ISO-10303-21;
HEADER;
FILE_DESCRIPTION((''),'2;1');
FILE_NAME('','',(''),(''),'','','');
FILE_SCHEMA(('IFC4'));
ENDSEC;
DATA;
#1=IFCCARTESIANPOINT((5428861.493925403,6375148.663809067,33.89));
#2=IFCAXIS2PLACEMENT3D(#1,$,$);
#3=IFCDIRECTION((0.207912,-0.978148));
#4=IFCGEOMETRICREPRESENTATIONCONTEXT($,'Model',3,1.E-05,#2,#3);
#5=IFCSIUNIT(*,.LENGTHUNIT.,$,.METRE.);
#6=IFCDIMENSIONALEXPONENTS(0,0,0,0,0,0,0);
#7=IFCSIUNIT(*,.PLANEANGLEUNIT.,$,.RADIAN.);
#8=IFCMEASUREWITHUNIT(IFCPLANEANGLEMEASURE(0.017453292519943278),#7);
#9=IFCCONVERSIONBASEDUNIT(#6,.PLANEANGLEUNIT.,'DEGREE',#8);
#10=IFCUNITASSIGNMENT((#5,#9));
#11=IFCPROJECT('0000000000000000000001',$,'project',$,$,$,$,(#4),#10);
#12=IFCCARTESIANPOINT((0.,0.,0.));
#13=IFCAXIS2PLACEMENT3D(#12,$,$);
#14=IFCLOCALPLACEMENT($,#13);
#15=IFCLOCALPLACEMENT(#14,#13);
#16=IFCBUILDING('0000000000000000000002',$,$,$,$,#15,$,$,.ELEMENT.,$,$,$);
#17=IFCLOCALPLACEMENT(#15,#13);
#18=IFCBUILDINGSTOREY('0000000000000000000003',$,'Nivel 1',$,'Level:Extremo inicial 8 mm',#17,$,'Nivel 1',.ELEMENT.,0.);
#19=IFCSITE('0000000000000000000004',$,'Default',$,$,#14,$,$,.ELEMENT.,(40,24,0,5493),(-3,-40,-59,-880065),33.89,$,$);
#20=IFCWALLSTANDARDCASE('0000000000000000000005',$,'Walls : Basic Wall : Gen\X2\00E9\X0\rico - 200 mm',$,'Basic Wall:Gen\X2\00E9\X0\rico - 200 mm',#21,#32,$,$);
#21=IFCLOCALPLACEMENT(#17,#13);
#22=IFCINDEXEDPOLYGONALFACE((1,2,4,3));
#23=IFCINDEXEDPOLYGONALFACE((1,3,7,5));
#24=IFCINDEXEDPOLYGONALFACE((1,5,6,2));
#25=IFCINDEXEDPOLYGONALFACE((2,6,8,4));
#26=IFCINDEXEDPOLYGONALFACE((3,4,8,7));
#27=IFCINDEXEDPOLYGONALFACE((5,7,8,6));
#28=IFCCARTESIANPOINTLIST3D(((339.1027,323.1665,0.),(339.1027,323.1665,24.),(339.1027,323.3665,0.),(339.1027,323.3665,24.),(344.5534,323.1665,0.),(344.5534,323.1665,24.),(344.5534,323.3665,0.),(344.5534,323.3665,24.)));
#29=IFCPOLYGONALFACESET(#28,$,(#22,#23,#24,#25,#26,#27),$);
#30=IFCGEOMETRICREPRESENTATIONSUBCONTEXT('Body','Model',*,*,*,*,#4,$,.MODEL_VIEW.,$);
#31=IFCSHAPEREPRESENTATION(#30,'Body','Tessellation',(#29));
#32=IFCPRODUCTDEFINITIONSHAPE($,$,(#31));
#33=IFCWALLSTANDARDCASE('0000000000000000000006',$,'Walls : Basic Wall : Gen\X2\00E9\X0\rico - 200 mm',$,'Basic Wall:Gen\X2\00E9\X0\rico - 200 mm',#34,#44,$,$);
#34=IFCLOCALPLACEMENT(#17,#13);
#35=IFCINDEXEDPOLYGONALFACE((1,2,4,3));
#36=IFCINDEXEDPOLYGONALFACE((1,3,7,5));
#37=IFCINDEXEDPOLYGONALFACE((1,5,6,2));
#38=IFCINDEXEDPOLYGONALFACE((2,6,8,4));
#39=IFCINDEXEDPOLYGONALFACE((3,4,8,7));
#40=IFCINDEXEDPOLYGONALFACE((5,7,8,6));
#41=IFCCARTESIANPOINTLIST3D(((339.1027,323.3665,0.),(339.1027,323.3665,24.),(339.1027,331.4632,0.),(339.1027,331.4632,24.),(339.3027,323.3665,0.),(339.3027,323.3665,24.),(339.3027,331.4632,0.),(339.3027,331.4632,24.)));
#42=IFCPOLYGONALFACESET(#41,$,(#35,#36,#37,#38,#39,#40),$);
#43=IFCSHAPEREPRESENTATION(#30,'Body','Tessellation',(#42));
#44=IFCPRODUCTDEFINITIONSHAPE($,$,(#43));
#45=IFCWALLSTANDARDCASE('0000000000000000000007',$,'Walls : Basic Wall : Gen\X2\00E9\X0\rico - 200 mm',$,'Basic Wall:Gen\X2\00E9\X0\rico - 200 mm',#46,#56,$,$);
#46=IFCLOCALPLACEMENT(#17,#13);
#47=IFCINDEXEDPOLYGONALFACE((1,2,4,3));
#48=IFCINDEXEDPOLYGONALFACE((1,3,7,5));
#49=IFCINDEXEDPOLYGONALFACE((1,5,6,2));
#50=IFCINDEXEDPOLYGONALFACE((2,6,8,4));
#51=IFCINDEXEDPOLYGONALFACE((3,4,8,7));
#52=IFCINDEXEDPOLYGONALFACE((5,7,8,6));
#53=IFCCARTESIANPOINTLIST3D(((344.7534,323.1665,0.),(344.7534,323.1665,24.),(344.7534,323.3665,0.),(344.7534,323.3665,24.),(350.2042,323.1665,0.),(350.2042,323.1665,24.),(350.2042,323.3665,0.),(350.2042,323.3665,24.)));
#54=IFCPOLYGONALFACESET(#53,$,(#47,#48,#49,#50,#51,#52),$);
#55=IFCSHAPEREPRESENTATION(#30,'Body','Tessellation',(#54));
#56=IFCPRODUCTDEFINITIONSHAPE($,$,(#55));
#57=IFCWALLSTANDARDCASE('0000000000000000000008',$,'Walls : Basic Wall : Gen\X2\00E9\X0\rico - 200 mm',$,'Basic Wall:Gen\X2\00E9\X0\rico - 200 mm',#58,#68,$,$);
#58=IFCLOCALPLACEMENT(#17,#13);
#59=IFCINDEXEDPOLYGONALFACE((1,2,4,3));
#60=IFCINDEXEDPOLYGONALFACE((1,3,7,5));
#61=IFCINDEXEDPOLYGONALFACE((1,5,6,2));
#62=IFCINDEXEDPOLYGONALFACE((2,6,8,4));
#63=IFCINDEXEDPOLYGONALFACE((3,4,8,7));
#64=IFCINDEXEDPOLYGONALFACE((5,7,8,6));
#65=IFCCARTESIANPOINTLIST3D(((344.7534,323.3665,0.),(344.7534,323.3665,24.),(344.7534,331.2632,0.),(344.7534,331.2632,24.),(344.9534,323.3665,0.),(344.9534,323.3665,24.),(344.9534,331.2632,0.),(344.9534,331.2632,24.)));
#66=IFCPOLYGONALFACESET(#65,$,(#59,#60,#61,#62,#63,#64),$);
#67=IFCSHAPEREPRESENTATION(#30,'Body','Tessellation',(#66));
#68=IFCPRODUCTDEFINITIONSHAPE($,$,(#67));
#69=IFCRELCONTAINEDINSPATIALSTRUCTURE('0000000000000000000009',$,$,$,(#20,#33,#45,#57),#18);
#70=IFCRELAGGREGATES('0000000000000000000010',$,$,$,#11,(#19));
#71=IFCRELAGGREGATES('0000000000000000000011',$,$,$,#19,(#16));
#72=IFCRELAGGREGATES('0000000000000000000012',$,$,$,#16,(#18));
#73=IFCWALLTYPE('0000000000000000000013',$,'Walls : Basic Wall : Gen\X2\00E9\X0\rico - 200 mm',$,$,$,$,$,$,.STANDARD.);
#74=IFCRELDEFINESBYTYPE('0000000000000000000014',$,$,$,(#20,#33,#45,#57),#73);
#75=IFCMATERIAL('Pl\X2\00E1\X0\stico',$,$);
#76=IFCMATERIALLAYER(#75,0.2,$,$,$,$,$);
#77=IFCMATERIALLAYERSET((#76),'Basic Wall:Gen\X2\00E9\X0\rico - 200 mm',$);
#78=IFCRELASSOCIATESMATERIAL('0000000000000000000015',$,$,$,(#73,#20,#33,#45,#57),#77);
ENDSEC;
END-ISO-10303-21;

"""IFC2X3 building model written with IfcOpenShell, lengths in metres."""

from ifc_helpers import new_model, entity, si_unit, converted_unit, direction, frame, frame_2d, origin, place, context, subcontext, project, spatial, rectangle, extrude, material, layer, layer_set, layer_usage, type_object, element, save


model = new_model("IFC2X3")

# Units and contexts
model_context = context("Model", 3, precision=1e-05, world=frame((5428861.493925403, 6375148.663809067, 33.89)), true_north=direction((0.207912, -0.978148)))
body_context = subcontext(model_context, "Body", "Model", "MODEL_VIEW")
ifc_project = project(units=[si_unit("LENGTHUNIT", "METRE"), converted_unit("PLANEANGLEUNIT", "DEGREE", entity("IfcPlaneAngleMeasure", 0.017453292519943278), si_unit("PLANEANGLEUNIT", "RADIAN"), dimensions=[0, 0, 0, 0, 0, 0, 0])], contexts=[model_context])

# Site, building, storey
site_placement = place(None, origin())
site = spatial("IfcSite", under=ifc_project, at=site_placement, Name="Default", CompositionType="ELEMENT", RefLatitude=(40, 24, 0, 5493), RefLongitude=(-3, -40, -59, -880065), RefElevation=33.89)
building_placement = place(site_placement, origin())
building = spatial("IfcBuilding", under=site, at=building_placement, CompositionType="ELEMENT")
storey_placement = place(building_placement, origin())
storey = spatial("IfcBuildingStorey", under=building, at=storey_placement, Name="Nivel 1", ObjectType="Level:Extremo inicial 8 mm", LongName="Nivel 1", CompositionType="ELEMENT", Elevation=0.0)

# Walls
ifc_material = material(Name="Plástico")
ifc_layer = layer(ifc_material, 0.2)
ifc_layer_set = layer_set([ifc_layer], Name="Basic Wall:Genérico - 200 mm")
wall_type = type_object("IfcWallType", Name="Walls : Basic Wall : Genérico - 200 mm", PredefinedType="STANDARD", material=ifc_layer_set)
ifc_layer_usage_1 = layer_usage(ifc_layer_set, "AXIS2", "NEGATIVE", 0.1)
wall_1_placement = place(storey_placement, frame((344.5534, 323.2665, 0.0), z_axis=(0.0, 0.0, 1.0), x_axis=(-1.0, 0.0, 0.0)))
element("IfcWallStandardCase", 1, at=wall_1_placement, inside=storey, type_object=wall_type, material=ifc_layer_usage_1, Name="Walls : Basic Wall : Genérico - 200 mm", ObjectType="Basic Wall:Genérico - 200 mm", context=body_context, shape_type="SweptSolid", body=[
    extrude(rectangle(XDim=5.4508, YDim=0.2, at=frame_2d((2.7254, 0.0), x_axis=(-1.0, 0.0))), origin(), (0.0, 0.0, 1.0), 24.0),
])
ifc_layer_usage_2 = layer_usage(ifc_layer_set, "AXIS2", "NEGATIVE", 0.1)
wall_2_placement = place(storey_placement, frame((339.2027, 323.3665, 0.0), z_axis=(0.0, 0.0, 1.0), x_axis=(0.0, 1.0, 0.0)))
element("IfcWallStandardCase", 2, at=wall_2_placement, inside=storey, type_object=wall_type, material=ifc_layer_usage_2, Name="Walls : Basic Wall : Genérico - 200 mm", ObjectType="Basic Wall:Genérico - 200 mm", context=body_context, shape_type="SweptSolid", body=[
    extrude(rectangle(XDim=8.0967, YDim=0.2, at=frame_2d((4.0484, 0.0), x_axis=(-1.0, 0.0))), origin(), (0.0, 0.0, 1.0), 24.0),
])
ifc_layer_usage_3 = layer_usage(ifc_layer_set, "AXIS2", "NEGATIVE", 0.1)
wall_3_placement = place(storey_placement, frame((350.2042, 323.2665, 0.0), z_axis=(0.0, 0.0, 1.0), x_axis=(-1.0, 0.0, 0.0)))
element("IfcWallStandardCase", 3, at=wall_3_placement, inside=storey, type_object=wall_type, material=ifc_layer_usage_3, Name="Walls : Basic Wall : Genérico - 200 mm", ObjectType="Basic Wall:Genérico - 200 mm", context=body_context, shape_type="SweptSolid", body=[
    extrude(rectangle(XDim=5.4508, YDim=0.2, at=frame_2d((2.7254, 0.0), x_axis=(-1.0, 0.0))), origin(), (0.0, 0.0, 1.0), 24.0),
])
ifc_layer_usage_4 = layer_usage(ifc_layer_set, "AXIS2", "NEGATIVE", 0.1)
wall_4_placement = place(storey_placement, frame((344.8534, 323.3665, 0.0), z_axis=(0.0, 0.0, 1.0), x_axis=(0.0, 1.0, 0.0)))
element("IfcWallStandardCase", 4, at=wall_4_placement, inside=storey, type_object=wall_type, material=ifc_layer_usage_4, Name="Walls : Basic Wall : Genérico - 200 mm", ObjectType="Basic Wall:Genérico - 200 mm", context=body_context, shape_type="SweptSolid", body=[
    extrude(rectangle(XDim=7.8967, YDim=0.2, at=frame_2d((3.9484, 0.0), x_axis=(-1.0, 0.0))), origin(), (0.0, 0.0, 1.0), 24.0),
])

save(model, "model.ifc")
